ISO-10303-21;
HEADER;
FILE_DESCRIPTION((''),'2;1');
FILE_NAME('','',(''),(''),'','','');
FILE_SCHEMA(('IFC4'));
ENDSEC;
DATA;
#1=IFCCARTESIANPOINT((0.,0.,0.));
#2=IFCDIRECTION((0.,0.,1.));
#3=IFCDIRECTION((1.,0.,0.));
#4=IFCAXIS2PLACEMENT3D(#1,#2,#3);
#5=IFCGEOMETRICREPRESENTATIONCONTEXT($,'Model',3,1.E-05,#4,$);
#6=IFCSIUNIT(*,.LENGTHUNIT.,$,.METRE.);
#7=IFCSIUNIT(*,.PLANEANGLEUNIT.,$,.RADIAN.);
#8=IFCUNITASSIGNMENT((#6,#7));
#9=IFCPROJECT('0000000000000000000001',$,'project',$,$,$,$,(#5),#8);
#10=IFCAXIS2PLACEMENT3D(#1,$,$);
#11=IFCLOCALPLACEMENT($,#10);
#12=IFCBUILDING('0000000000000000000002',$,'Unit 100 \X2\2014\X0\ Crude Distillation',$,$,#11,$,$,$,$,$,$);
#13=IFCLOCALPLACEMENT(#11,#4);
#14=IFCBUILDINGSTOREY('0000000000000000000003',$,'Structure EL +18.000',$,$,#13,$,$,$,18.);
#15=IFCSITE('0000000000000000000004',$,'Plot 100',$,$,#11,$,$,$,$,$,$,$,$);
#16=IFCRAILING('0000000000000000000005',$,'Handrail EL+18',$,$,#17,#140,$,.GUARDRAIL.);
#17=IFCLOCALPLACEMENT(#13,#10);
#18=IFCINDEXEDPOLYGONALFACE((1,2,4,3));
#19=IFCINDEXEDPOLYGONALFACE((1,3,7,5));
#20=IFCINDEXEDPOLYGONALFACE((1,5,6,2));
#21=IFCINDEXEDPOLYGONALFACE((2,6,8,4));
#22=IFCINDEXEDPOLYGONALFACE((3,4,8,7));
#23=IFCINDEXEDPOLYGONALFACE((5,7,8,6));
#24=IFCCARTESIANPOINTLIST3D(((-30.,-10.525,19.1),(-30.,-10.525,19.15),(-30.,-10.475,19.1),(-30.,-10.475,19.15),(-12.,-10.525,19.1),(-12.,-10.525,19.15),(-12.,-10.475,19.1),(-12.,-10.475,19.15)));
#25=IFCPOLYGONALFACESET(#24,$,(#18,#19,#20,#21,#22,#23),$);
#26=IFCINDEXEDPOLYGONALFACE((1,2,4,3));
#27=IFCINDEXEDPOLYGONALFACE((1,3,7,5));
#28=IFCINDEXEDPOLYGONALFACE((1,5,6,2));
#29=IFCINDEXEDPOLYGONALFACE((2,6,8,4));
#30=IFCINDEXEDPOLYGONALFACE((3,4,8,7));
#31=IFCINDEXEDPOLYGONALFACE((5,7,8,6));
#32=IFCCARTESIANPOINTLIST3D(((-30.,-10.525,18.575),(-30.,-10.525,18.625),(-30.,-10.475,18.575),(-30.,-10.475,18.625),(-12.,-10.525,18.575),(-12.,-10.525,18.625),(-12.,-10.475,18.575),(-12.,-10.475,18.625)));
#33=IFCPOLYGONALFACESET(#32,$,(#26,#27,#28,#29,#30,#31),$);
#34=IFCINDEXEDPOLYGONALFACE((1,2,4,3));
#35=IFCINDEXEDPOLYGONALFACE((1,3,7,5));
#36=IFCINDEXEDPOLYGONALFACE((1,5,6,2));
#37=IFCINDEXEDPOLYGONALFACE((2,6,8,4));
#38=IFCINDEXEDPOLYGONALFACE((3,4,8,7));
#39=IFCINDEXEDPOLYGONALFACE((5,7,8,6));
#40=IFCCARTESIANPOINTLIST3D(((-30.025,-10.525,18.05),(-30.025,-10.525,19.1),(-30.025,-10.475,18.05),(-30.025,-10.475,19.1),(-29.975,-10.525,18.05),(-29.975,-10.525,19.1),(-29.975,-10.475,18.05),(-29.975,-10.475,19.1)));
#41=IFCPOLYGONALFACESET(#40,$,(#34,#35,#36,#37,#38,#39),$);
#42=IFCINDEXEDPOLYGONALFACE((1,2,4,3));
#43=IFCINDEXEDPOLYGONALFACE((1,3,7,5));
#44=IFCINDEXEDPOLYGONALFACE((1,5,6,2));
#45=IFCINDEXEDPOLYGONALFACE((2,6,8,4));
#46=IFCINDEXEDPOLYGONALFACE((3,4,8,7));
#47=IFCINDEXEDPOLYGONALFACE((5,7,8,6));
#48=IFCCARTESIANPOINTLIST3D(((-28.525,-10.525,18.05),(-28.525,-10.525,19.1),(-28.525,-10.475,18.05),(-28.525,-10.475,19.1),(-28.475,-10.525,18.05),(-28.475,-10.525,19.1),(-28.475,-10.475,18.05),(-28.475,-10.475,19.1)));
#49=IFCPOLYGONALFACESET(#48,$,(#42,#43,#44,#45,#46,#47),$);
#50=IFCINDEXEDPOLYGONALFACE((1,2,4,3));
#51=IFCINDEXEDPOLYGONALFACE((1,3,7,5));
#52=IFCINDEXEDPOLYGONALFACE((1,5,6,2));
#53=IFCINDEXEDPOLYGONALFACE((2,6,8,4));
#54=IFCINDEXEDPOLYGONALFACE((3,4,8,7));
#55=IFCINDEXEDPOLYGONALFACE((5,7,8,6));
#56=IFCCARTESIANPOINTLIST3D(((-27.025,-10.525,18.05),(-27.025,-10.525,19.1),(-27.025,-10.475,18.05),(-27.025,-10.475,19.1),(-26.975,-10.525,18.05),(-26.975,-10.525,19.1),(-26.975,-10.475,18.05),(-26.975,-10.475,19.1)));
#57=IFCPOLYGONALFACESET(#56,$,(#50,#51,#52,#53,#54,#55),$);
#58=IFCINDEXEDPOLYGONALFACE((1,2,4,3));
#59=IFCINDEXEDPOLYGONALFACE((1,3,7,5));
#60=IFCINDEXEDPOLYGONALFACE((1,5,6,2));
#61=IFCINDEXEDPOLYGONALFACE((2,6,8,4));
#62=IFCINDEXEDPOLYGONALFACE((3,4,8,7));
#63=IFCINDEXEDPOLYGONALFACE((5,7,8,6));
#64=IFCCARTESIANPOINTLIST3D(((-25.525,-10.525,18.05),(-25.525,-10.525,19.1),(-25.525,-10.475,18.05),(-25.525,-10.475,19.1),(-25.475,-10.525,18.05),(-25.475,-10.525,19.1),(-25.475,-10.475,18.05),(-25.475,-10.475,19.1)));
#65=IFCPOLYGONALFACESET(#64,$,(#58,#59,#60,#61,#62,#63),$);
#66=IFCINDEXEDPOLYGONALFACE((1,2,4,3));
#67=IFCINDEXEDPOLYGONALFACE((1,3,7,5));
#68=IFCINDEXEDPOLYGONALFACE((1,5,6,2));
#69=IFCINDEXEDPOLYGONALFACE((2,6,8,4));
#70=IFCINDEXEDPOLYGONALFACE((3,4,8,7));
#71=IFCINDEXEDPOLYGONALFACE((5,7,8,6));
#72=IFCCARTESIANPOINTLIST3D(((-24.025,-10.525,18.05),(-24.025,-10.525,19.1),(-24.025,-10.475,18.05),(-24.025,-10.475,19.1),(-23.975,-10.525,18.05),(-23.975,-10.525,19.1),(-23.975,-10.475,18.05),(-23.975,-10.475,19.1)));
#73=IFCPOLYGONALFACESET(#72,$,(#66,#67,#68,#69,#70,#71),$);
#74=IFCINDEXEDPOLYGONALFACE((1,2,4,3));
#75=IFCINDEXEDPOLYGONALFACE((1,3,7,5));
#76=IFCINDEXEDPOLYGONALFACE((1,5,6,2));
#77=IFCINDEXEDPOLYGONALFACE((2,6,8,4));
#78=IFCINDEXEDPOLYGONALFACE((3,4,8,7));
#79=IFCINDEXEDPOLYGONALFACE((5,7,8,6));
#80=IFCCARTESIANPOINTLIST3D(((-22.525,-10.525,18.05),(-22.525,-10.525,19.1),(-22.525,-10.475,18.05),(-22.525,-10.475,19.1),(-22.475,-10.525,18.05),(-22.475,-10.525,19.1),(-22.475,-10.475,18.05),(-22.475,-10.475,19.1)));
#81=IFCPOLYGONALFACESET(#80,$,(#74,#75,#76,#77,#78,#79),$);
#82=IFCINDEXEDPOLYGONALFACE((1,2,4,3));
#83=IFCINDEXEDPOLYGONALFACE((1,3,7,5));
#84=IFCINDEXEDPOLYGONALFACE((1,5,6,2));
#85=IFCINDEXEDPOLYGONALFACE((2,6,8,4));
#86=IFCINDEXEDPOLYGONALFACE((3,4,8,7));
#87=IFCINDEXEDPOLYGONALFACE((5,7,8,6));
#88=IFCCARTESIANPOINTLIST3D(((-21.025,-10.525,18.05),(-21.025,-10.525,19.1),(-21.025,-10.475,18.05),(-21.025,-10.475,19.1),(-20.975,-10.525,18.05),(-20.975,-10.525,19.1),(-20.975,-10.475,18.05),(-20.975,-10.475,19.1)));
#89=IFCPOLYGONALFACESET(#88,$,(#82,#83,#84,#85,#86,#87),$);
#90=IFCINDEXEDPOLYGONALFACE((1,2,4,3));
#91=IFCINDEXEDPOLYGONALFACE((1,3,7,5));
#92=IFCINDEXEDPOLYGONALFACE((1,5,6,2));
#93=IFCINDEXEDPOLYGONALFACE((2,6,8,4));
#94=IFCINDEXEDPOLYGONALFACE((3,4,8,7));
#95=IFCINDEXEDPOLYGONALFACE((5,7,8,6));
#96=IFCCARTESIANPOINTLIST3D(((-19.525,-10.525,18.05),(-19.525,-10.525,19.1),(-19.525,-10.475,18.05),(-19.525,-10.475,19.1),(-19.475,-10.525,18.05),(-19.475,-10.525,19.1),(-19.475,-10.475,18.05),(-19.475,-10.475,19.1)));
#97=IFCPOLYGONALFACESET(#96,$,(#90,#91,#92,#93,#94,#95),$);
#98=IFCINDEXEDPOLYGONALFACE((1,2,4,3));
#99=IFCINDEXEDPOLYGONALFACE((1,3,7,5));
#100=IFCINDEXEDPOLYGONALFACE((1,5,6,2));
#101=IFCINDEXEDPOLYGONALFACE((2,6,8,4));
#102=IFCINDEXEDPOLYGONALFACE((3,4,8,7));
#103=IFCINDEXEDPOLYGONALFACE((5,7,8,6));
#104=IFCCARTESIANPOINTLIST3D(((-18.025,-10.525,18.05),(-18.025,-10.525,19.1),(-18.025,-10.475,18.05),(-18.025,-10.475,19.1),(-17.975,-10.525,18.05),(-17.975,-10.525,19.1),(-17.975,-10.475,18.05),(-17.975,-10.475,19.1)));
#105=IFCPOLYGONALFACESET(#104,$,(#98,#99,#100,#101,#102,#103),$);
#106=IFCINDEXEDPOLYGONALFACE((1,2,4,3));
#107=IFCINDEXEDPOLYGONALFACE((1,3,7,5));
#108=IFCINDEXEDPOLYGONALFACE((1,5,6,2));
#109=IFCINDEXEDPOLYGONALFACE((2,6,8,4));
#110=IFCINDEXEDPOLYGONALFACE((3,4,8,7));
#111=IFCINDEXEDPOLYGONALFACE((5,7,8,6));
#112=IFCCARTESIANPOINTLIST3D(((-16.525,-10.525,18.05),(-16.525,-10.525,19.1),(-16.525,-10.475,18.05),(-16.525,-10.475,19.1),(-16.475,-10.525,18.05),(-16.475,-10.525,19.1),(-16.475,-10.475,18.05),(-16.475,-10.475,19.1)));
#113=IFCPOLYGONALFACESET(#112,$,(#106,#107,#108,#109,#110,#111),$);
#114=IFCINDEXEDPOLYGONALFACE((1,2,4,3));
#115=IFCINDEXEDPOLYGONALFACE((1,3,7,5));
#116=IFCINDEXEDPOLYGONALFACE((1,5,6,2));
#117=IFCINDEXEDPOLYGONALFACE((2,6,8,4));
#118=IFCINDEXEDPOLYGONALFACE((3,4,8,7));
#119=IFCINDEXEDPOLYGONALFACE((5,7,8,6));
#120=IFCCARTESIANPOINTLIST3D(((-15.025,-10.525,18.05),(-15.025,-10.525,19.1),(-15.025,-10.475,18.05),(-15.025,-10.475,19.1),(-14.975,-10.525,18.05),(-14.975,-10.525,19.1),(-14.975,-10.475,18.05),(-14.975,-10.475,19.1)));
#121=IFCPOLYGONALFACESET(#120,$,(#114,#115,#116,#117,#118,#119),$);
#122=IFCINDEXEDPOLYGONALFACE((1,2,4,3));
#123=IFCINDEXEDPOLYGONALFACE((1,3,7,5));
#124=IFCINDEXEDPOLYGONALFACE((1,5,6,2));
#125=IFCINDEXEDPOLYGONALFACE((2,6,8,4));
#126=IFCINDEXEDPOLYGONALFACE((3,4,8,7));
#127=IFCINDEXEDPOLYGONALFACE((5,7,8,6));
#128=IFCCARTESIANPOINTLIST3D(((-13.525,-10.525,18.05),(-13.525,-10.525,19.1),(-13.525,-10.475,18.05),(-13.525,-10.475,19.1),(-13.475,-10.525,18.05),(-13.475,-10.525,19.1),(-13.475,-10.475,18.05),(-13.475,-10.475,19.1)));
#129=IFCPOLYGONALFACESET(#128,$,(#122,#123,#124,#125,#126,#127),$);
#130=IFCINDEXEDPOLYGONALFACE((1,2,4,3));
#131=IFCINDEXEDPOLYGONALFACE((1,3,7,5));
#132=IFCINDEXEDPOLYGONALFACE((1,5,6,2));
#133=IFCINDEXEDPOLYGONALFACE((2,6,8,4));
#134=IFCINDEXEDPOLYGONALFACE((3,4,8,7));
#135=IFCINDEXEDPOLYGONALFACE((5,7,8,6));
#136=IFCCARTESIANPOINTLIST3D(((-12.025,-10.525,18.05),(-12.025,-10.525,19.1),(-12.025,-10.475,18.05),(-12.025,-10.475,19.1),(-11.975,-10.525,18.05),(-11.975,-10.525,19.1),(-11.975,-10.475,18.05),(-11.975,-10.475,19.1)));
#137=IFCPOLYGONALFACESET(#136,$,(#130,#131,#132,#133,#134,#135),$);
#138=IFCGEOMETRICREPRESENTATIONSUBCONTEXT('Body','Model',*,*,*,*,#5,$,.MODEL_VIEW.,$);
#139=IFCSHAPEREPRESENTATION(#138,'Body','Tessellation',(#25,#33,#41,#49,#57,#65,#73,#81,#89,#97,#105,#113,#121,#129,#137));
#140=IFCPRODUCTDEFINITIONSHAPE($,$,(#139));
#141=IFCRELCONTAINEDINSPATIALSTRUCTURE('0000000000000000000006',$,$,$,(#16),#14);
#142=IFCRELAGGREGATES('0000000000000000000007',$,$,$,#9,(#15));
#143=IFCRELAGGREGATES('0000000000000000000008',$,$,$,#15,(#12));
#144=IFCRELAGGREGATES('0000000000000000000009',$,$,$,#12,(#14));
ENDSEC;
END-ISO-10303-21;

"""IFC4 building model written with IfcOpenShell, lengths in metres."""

from ifc_helpers import new_model, si_unit, frame, origin, origin_with_axes, origin_2d, place, context, subcontext, project, spatial, rectangle, extrude, element, save


model = new_model("IFC4")

# Units and contexts
model_context = context("Model", 3, precision=1e-05, world=origin_with_axes())
body_context = subcontext(model_context, "Body", "Model", "MODEL_VIEW")
ifc_project = project(units=[si_unit("LENGTHUNIT", "METRE"), si_unit("PLANEANGLEUNIT", "RADIAN")], contexts=[model_context])

# Site, building, storey
placement = place(None, origin())
site = spatial("IfcSite", under=ifc_project, at=placement, Name="Plot 100")
building = spatial("IfcBuilding", under=site, at=placement, Name="Unit 100 — Crude Distillation")
storey_placement = place(placement, origin_with_axes())
storey = spatial("IfcBuildingStorey", under=building, at=storey_placement, Name="Structure EL +18.000", Elevation=18.0)

# Railing
railing_1_placement = place(storey_placement, origin_with_axes())
element("IfcRailing", 1, at=railing_1_placement, inside=storey, Name="Handrail EL+18", PredefinedType="GUARDRAIL", context=body_context, shape_type="SweptSolid", body=[
    extrude(rectangle(XDim=0.05, YDim=0.05, at=origin_2d()), frame((-30.0, -10.5, 19.125), z_axis=(1.0, 0.0, 0.0), x_axis=(0.0, 1.0, 0.0)), (0.0, 0.0, 1.0), 18.0),
    extrude(rectangle(XDim=0.05, YDim=0.05, at=origin_2d()), frame((-30.0, -10.5, 18.6), z_axis=(1.0, 0.0, 0.0), x_axis=(0.0, 1.0, 0.0)), (0.0, 0.0, 1.0), 18.0),
    extrude(rectangle(XDim=0.05, YDim=0.05, at=origin_2d()), frame((-30.0, -10.5, 18.05), z_axis=(0.0, 0.0, 1.0), x_axis=(1.0, 0.0, 0.0)), (0.0, 0.0, 1.0), 1.05),
    extrude(rectangle(XDim=0.05, YDim=0.05, at=origin_2d()), frame((-28.5, -10.5, 18.05), z_axis=(0.0, 0.0, 1.0), x_axis=(1.0, 0.0, 0.0)), (0.0, 0.0, 1.0), 1.05),
    extrude(rectangle(XDim=0.05, YDim=0.05, at=origin_2d()), frame((-27.0, -10.5, 18.05), z_axis=(0.0, 0.0, 1.0), x_axis=(1.0, 0.0, 0.0)), (0.0, 0.0, 1.0), 1.05),
    extrude(rectangle(XDim=0.05, YDim=0.05, at=origin_2d()), frame((-25.5, -10.5, 18.05), z_axis=(0.0, 0.0, 1.0), x_axis=(1.0, 0.0, 0.0)), (0.0, 0.0, 1.0), 1.05),
    extrude(rectangle(XDim=0.05, YDim=0.05, at=origin_2d()), frame((-24.0, -10.5, 18.05), z_axis=(0.0, 0.0, 1.0), x_axis=(1.0, 0.0, 0.0)), (0.0, 0.0, 1.0), 1.05),
    extrude(rectangle(XDim=0.05, YDim=0.05, at=origin_2d()), frame((-22.5, -10.5, 18.05), z_axis=(0.0, 0.0, 1.0), x_axis=(1.0, 0.0, 0.0)), (0.0, 0.0, 1.0), 1.05),
    extrude(rectangle(XDim=0.05, YDim=0.05, at=origin_2d()), frame((-21.0, -10.5, 18.05), z_axis=(0.0, 0.0, 1.0), x_axis=(1.0, 0.0, 0.0)), (0.0, 0.0, 1.0), 1.05),
    extrude(rectangle(XDim=0.05, YDim=0.05, at=origin_2d()), frame((-19.5, -10.5, 18.05), z_axis=(0.0, 0.0, 1.0), x_axis=(1.0, 0.0, 0.0)), (0.0, 0.0, 1.0), 1.05),
    extrude(rectangle(XDim=0.05, YDim=0.05, at=origin_2d()), frame((-18.0, -10.5, 18.05), z_axis=(0.0, 0.0, 1.0), x_axis=(1.0, 0.0, 0.0)), (0.0, 0.0, 1.0), 1.05),
    extrude(rectangle(XDim=0.05, YDim=0.05, at=origin_2d()), frame((-16.5, -10.5, 18.05), z_axis=(0.0, 0.0, 1.0), x_axis=(1.0, 0.0, 0.0)), (0.0, 0.0, 1.0), 1.05),
    extrude(rectangle(XDim=0.05, YDim=0.05, at=origin_2d()), frame((-15.0, -10.5, 18.05), z_axis=(0.0, 0.0, 1.0), x_axis=(1.0, 0.0, 0.0)), (0.0, 0.0, 1.0), 1.05),
    extrude(rectangle(XDim=0.05, YDim=0.05, at=origin_2d()), frame((-13.5, -10.5, 18.05), z_axis=(0.0, 0.0, 1.0), x_axis=(1.0, 0.0, 0.0)), (0.0, 0.0, 1.0), 1.05),
    extrude(rectangle(XDim=0.05, YDim=0.05, at=origin_2d()), frame((-12.0, -10.5, 18.05), z_axis=(0.0, 0.0, 1.0), x_axis=(1.0, 0.0, 0.0)), (0.0, 0.0, 1.0), 1.05),
])

save(model, "model.ifc")
